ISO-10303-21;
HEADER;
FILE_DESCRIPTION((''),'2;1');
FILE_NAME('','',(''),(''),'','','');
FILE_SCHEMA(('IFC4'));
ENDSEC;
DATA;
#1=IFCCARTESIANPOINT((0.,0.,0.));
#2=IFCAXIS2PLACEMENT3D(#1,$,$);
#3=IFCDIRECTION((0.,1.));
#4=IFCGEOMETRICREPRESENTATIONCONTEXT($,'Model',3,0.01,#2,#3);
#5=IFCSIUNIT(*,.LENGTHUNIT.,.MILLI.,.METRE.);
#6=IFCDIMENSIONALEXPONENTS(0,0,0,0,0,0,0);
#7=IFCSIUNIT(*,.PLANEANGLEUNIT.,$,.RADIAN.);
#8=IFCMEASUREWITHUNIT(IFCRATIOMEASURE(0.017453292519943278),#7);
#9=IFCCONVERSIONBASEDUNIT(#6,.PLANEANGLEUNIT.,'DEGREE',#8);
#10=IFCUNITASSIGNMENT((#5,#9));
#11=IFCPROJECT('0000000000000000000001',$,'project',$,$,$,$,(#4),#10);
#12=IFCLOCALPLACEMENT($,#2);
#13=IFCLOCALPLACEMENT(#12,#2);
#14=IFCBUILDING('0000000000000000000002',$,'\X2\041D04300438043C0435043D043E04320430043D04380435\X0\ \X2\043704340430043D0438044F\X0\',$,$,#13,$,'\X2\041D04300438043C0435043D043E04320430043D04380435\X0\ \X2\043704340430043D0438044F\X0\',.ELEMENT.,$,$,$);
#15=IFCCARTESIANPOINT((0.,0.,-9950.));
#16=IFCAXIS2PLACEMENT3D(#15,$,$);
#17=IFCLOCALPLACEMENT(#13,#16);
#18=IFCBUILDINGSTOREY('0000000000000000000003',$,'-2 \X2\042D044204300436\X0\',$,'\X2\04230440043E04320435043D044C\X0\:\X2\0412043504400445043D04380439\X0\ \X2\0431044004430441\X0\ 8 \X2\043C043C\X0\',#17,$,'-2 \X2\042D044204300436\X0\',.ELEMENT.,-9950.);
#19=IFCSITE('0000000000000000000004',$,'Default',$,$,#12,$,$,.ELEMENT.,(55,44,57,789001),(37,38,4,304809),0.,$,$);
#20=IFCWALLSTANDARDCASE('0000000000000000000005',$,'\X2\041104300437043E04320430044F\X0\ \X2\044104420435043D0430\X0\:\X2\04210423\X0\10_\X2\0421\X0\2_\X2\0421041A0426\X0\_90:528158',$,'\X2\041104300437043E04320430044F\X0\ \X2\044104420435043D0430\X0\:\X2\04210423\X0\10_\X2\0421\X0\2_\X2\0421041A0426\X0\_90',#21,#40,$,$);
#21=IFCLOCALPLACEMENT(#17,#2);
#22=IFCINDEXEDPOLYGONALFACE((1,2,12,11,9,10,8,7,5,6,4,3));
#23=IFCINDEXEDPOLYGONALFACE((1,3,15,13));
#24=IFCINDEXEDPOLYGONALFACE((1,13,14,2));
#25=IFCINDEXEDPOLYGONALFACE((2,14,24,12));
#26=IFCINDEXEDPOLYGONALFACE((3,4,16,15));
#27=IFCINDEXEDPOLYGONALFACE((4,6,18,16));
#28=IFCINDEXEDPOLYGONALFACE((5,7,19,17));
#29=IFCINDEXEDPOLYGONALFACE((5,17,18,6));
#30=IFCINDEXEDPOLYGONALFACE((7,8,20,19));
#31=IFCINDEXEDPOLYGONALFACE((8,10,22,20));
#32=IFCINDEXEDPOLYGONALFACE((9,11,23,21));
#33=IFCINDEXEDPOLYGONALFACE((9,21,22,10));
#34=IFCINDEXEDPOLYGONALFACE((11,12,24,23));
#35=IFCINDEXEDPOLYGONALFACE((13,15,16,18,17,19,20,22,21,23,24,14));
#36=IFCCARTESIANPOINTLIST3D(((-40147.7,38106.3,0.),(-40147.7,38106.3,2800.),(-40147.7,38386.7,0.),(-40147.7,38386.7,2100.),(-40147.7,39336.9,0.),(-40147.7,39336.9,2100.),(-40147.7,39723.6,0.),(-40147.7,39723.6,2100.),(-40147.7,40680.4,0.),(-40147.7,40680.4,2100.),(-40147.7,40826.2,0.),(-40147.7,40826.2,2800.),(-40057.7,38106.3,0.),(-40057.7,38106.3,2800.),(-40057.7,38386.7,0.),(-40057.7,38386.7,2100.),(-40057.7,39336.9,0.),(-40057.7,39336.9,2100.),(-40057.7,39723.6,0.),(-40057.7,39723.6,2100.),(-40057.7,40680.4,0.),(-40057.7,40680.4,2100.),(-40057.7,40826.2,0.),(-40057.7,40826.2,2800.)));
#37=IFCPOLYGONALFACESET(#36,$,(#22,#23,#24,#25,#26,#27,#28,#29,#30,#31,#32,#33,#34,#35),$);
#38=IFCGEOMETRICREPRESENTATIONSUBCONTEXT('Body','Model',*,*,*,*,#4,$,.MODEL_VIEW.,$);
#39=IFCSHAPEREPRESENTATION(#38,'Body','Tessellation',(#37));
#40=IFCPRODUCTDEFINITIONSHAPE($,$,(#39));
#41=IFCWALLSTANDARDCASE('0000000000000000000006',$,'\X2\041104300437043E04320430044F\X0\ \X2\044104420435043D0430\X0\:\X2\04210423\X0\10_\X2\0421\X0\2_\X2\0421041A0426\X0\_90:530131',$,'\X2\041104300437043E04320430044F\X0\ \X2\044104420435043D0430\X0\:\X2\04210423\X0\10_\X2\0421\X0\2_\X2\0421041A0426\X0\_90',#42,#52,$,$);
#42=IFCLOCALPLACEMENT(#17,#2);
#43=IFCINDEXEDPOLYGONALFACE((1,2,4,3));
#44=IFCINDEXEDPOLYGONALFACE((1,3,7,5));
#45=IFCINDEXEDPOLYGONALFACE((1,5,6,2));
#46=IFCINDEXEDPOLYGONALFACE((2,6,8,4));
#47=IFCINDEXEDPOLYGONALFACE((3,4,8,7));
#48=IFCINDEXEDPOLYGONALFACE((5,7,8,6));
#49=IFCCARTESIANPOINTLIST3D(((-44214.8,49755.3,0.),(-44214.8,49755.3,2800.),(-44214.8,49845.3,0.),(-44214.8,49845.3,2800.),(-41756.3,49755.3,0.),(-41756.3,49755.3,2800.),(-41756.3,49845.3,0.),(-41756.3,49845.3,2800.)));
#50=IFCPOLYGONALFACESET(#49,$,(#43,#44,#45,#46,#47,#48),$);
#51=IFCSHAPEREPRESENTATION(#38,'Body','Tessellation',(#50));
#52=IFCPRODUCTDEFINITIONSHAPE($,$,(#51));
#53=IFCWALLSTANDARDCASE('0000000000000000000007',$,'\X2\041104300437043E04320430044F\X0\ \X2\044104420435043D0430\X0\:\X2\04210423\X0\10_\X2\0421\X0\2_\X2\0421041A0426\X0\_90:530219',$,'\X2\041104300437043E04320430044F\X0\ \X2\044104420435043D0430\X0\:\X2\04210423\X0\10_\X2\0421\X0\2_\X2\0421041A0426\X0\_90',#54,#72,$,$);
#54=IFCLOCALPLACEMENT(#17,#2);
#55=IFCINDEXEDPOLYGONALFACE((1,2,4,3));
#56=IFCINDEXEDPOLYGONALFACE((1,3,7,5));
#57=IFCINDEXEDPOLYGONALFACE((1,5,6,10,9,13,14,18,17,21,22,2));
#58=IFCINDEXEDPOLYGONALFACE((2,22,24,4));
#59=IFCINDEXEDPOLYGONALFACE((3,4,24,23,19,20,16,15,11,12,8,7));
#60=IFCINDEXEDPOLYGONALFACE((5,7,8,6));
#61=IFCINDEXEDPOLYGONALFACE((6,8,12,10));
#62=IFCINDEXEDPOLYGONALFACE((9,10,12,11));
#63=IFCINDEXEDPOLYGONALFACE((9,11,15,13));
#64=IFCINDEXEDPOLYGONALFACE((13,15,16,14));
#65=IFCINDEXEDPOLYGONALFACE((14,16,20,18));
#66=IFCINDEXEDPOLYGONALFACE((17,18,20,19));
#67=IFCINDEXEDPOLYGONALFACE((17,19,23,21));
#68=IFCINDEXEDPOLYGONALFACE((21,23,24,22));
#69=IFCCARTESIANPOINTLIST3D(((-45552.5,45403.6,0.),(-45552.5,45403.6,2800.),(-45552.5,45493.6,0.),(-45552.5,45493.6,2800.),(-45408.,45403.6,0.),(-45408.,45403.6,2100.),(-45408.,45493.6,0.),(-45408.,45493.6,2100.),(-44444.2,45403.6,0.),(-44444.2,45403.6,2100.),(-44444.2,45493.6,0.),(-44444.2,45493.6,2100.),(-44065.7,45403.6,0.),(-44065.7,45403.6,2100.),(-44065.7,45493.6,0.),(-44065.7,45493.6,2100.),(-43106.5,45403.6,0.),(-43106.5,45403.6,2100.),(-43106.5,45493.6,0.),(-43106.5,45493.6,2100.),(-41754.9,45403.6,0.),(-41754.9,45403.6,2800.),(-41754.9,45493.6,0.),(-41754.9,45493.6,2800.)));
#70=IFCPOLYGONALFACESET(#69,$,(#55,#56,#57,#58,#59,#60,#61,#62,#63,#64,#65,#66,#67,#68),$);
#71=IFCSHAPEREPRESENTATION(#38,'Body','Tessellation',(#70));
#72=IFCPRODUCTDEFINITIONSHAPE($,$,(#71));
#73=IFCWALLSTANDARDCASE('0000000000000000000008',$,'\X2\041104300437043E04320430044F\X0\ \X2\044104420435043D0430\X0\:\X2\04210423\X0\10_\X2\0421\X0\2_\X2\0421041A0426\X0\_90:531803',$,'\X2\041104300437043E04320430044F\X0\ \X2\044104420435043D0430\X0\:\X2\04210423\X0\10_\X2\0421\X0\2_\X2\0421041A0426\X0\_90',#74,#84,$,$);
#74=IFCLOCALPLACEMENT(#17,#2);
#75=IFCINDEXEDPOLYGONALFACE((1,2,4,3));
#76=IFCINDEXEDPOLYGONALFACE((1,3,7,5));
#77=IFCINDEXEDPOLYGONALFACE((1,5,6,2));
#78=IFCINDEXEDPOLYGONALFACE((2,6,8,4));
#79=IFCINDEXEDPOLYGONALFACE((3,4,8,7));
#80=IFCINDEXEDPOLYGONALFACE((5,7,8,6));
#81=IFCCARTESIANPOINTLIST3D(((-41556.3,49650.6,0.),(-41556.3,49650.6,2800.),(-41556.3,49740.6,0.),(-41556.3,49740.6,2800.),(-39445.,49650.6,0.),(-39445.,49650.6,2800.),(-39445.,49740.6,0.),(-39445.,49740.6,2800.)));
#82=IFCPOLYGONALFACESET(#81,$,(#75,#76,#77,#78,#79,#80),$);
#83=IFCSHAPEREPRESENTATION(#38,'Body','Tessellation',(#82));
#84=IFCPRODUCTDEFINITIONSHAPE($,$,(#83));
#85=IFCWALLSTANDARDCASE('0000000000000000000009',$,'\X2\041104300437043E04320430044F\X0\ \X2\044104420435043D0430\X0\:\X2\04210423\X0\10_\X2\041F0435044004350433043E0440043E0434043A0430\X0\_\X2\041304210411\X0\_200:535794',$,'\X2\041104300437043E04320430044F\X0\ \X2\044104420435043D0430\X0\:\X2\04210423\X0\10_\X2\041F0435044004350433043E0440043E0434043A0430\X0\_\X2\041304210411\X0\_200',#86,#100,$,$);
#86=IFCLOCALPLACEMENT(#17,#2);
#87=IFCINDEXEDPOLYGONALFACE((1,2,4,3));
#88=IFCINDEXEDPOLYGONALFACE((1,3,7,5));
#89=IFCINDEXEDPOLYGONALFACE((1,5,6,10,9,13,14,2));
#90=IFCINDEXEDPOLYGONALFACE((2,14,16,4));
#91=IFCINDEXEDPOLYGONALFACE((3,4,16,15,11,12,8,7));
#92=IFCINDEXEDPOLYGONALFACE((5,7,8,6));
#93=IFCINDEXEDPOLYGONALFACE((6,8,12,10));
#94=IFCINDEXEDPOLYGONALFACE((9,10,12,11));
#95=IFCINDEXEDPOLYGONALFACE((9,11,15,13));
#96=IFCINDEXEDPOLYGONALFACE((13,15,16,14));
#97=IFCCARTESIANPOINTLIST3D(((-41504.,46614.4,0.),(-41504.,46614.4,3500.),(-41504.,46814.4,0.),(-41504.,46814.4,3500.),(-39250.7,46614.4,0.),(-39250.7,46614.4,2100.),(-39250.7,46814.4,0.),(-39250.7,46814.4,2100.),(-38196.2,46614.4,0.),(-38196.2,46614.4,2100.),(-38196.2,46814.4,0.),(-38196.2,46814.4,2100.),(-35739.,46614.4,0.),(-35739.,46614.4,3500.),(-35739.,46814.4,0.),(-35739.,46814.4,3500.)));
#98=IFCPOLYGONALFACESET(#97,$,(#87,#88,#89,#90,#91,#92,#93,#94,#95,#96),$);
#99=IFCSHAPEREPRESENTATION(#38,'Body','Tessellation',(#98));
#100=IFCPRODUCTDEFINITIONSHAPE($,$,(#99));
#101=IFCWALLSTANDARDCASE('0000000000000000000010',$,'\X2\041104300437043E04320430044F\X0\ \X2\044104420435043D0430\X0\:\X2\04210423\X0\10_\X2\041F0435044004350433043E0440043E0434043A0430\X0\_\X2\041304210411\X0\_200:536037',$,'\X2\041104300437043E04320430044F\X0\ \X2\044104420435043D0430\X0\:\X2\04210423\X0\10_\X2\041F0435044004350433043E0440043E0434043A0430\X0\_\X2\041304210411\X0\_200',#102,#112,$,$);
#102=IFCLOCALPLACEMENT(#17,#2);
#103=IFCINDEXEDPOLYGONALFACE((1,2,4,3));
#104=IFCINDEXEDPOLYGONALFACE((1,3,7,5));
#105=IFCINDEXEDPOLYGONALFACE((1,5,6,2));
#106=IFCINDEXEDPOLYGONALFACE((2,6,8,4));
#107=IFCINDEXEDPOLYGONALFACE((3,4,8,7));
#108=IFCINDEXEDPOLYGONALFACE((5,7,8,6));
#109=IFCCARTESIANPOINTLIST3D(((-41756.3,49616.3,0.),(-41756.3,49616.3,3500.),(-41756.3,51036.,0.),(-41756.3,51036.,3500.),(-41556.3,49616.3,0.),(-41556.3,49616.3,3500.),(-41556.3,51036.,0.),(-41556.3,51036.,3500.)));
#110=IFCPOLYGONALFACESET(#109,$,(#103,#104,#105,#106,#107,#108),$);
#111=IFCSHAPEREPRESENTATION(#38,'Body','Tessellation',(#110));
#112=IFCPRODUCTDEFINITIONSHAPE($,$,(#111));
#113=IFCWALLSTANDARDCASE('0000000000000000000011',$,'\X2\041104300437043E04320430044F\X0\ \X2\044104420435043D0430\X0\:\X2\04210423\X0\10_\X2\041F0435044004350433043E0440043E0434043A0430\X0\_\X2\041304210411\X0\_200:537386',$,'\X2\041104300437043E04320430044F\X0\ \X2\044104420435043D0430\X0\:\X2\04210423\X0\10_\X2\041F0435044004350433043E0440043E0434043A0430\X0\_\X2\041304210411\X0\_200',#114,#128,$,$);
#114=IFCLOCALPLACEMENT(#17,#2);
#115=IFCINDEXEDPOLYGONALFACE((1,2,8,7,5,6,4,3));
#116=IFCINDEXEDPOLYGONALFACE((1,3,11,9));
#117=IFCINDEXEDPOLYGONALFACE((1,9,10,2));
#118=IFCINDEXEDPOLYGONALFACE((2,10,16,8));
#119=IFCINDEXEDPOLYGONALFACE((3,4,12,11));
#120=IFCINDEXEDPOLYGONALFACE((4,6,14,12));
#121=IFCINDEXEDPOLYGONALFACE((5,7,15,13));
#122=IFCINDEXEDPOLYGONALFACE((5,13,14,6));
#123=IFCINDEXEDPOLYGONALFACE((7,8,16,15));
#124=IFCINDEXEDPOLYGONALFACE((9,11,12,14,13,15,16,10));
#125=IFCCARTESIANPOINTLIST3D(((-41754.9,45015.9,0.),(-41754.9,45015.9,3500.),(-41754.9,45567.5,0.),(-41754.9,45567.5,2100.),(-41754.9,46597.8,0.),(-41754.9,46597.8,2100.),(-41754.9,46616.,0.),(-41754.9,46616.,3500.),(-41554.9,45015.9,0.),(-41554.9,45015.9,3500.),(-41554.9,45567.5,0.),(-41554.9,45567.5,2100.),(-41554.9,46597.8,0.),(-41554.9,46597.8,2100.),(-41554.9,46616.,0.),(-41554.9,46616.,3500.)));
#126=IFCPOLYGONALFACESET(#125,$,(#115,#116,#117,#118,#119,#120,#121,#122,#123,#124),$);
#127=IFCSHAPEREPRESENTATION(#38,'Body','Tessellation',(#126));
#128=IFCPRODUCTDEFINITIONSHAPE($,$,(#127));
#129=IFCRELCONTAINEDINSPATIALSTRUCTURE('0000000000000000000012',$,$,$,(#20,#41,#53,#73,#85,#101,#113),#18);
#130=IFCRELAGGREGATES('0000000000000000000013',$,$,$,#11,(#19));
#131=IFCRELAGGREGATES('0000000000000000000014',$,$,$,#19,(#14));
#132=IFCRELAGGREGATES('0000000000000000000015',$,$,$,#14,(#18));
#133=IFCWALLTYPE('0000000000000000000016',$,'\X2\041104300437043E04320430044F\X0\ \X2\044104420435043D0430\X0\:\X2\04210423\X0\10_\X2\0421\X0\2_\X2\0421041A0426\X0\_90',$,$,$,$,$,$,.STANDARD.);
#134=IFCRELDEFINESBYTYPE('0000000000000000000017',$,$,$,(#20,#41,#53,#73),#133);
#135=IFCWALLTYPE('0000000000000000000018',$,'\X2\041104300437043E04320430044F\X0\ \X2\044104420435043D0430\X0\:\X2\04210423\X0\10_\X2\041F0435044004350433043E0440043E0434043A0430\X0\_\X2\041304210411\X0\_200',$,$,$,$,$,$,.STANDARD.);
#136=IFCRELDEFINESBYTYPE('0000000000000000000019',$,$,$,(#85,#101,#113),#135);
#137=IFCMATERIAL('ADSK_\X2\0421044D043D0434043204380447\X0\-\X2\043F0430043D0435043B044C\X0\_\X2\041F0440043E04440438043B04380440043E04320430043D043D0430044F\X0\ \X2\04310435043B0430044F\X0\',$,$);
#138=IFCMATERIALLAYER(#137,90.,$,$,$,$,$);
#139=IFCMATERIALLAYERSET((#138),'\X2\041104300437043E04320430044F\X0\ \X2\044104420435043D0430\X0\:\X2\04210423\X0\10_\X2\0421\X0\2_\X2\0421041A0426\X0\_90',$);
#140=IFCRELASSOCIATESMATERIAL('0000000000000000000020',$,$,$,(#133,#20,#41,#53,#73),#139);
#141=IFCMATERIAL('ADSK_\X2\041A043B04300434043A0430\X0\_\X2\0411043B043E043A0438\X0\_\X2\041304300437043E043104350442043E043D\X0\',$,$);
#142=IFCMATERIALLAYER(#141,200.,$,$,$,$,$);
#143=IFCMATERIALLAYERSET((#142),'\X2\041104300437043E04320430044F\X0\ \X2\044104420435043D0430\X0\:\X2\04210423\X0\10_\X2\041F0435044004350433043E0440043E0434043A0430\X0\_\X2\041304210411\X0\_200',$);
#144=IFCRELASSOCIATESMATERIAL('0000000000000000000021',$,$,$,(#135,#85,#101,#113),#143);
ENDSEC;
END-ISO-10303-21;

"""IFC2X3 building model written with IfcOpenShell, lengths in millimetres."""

from ifc_helpers import new_model, entity, si_unit, converted_unit, direction, frame, frame_2d, origin, place, context, subcontext, project, spatial, rectangle, extrude, material, layer, layer_set, layer_usage, type_object, element, save


model = new_model("IFC2X3")

# Units and contexts
model_context = context("Model", 3, precision=0.01, world=origin(), true_north=direction((0.0, 1.0)))
body_context = subcontext(model_context, "Body", "Model", "MODEL_VIEW")
ifc_project = project(units=[si_unit("LENGTHUNIT", "METRE", prefix="MILLI"), converted_unit("PLANEANGLEUNIT", "DEGREE", entity("IfcRatioMeasure", 0.017453292519943278), si_unit("PLANEANGLEUNIT", "RADIAN"), dimensions=[0, 0, 0, 0, 0, 0, 0])], contexts=[model_context])

# Site, building, storey
site_placement = place(None, origin())
site = spatial("IfcSite", under=ifc_project, at=site_placement, Name="Default", CompositionType="ELEMENT", RefLatitude=(55, 44, 57, 789001), RefLongitude=(37, 38, 4, 304809), RefElevation=0.0)
building_placement = place(site_placement, origin())
building = spatial("IfcBuilding", under=site, at=building_placement, Name="Наименование здания", LongName="Наименование здания", CompositionType="ELEMENT")
storey_placement = place(building_placement, frame((0.0, 0.0, -9950.0)))
storey = spatial("IfcBuildingStorey", under=building, at=storey_placement, Name="-2 Этаж", ObjectType="Уровень:Верхний брус 8 мм", LongName="-2 Этаж", CompositionType="ELEMENT", Elevation=-9950.0)

# Shared definitions
ifc_material_1 = material(Name="ADSK_Сэндвич-панель_Профилированная белая")
ifc_layer_1 = layer(ifc_material_1, 90.0)
ifc_layer_set_1 = layer_set([ifc_layer_1], Name="Базовая стена:СУ10_С2_СКЦ_90")
ifc_layer_usage_1 = layer_usage(ifc_layer_set_1, "AXIS2", "NEGATIVE", 45.0)
wall_type_1 = type_object("IfcWallType", Name="Базовая стена:СУ10_С2_СКЦ_90", PredefinedType="STANDARD", material=ifc_layer_set_1)

# Wall, openings
wall_1_placement = place(storey_placement, frame((-40102.7, 40826.2, 0.0), z_axis=(0.0, 0.0, 1.0), x_axis=(0.0, -1.0, 0.0)))
wall_1 = element("IfcWallStandardCase", 1, at=wall_1_placement, inside=storey, type_object=wall_type_1, material=ifc_layer_usage_1, Name="Базовая стена:СУ10_С2_СКЦ_90:528158", ObjectType="Базовая стена:СУ10_С2_СКЦ_90", context=body_context, shape_type="SweptSolid", body=[
    extrude(rectangle(XDim=2719.9, YDim=90.0, at=frame_2d((1359.9, 0.0), x_axis=(1.0, 0.0))), origin(), (0.0, 0.0, 1.0), 2800.0),
])
opening_1_placement = place(wall_1_placement, origin())
element("IfcOpeningElement", 2, at=opening_1_placement, cuts=wall_1, ObjectType="Opening", context=body_context, shape_type="SweptSolid", body=[
    extrude(rectangle(XDim=2100.0, YDim=956.8, at=frame_2d((0.0, 0.0), x_axis=(1.0, 0.0))), frame((624.2, -45.0, 1050.0), z_axis=(0.0, 1.0, 0.0), x_axis=(0.0, 0.0, -1.0)), (0.0, 0.0, 1.0), 90.0),
])
opening_2_placement = place(wall_1_placement, origin())
element("IfcOpeningElement", 3, at=opening_2_placement, cuts=wall_1, ObjectType="Opening", context=body_context, shape_type="SweptSolid", body=[
    extrude(rectangle(XDim=2100.0, YDim=950.2, at=frame_2d((0.0, 0.0), x_axis=(1.0, 0.0))), frame((1964.4, -45.0, 1050.0), z_axis=(0.0, 1.0, 0.0), x_axis=(0.0, 0.0, -1.0)), (0.0, 0.0, 1.0), 90.0),
])

# Wall
wall_2_placement = place(storey_placement, frame((-41756.3, 49800.3, 0.0), z_axis=(0.0, 0.0, 1.0), x_axis=(-1.0, 0.0, 0.0)))
element("IfcWallStandardCase", 4, at=wall_2_placement, inside=storey, type_object=wall_type_1, material=ifc_layer_usage_1, Name="Базовая стена:СУ10_С2_СКЦ_90:530131", ObjectType="Базовая стена:СУ10_С2_СКЦ_90", context=body_context, shape_type="SweptSolid", body=[
    extrude(rectangle(XDim=2458.5, YDim=90.0, at=frame_2d((1229.2, 0.0), x_axis=(-1.0, 0.0))), origin(), (0.0, 0.0, 1.0), 2800.0),
])

# Wall, openings
wall_3_placement = place(storey_placement, frame((-41754.9, 45448.6, 0.0), z_axis=(0.0, 0.0, 1.0), x_axis=(-1.0, 0.0, 0.0)))
wall_3 = element("IfcWallStandardCase", 5, at=wall_3_placement, inside=storey, type_object=wall_type_1, material=ifc_layer_usage_1, Name="Базовая стена:СУ10_С2_СКЦ_90:530219", ObjectType="Базовая стена:СУ10_С2_СКЦ_90", context=body_context, shape_type="SweptSolid", body=[
    extrude(rectangle(XDim=3797.6, YDim=90.0, at=frame_2d((1898.8, 0.0), x_axis=(1.0, 0.0))), origin(), (0.0, 0.0, 1.0), 2800.0),
])
opening_3_placement = place(wall_3_placement, origin())
element("IfcOpeningElement", 6, at=opening_3_placement, cuts=wall_3, ObjectType="Opening", context=body_context, shape_type="SweptSolid", body=[
    extrude(rectangle(XDim=2100.0, YDim=963.8, at=frame_2d((0.0, 0.0), x_axis=(1.0, 0.0))), frame((3171.2, -45.0, 1050.0), z_axis=(0.0, 1.0, 0.0), x_axis=(0.0, 0.0, -1.0)), (0.0, 0.0, 1.0), 90.0),
])
opening_4_placement = place(wall_3_placement, origin())
element("IfcOpeningElement", 7, at=opening_4_placement, cuts=wall_3, ObjectType="Opening", context=body_context, shape_type="SweptSolid", body=[
    extrude(rectangle(XDim=2100.0, YDim=959.3, at=frame_2d((0.0, 0.0), x_axis=(1.0, 0.0))), frame((1831.2, -45.0, 1050.0), z_axis=(0.0, 1.0, 0.0), x_axis=(0.0, 0.0, -1.0)), (0.0, 0.0, 1.0), 90.0),
])

# Wall
wall_4_placement = place(storey_placement, frame((-39445.0, 49695.6, 0.0), z_axis=(0.0, 0.0, 1.0), x_axis=(-1.0, 0.0, 0.0)))
element("IfcWallStandardCase", 8, at=wall_4_placement, inside=storey, type_object=wall_type_1, material=ifc_layer_usage_1, Name="Базовая стена:СУ10_С2_СКЦ_90:531803", ObjectType="Базовая стена:СУ10_С2_СКЦ_90", context=body_context, shape_type="SweptSolid", body=[
    extrude(rectangle(XDim=2111.3, YDim=90.0, at=frame_2d((1055.6, 0.0), x_axis=(-1.0, 0.0))), origin(), (0.0, 0.0, 1.0), 2800.0),
])

# Wall, opening
ifc_material_2 = material(Name="ADSK_Кладка_Блоки_Газобетон")
ifc_layer_2 = layer(ifc_material_2, 200.0)
ifc_layer_set_2 = layer_set([ifc_layer_2], Name="Базовая стена:СУ10_Перегородка_ГСБ_200")
ifc_layer_usage_2 = layer_usage(ifc_layer_set_2, "AXIS2", "NEGATIVE", 100.0)
wall_type_2 = type_object("IfcWallType", Name="Базовая стена:СУ10_Перегородка_ГСБ_200", PredefinedType="STANDARD", material=ifc_layer_set_2)
wall_5_placement = place(storey_placement, frame((-35739.0, 46714.4, 0.0), z_axis=(0.0, 0.0, 1.0), x_axis=(-1.0, 0.0, 0.0)))
wall_5 = element("IfcWallStandardCase", 9, at=wall_5_placement, inside=storey, type_object=wall_type_2, material=ifc_layer_usage_2, Name="Базовая стена:СУ10_Перегородка_ГСБ_200:535794", ObjectType="Базовая стена:СУ10_Перегородка_ГСБ_200", context=body_context, shape_type="SweptSolid", body=[
    extrude(rectangle(XDim=5765.0, YDim=200.0, at=frame_2d((2882.5, 0.0), x_axis=(-1.0, 0.0))), origin(), (0.0, 0.0, 1.0), 3500.0),
])
opening_5_placement = place(wall_5_placement, origin())
element("IfcOpeningElement", 10, at=opening_5_placement, cuts=wall_5, ObjectType="Opening", context=body_context, shape_type="SweptSolid", body=[
    extrude(rectangle(XDim=2100.0, YDim=1054.4, at=frame_2d((0.0, 0.0), x_axis=(1.0, 0.0))), frame((2984.5, -100.0, 1050.0), z_axis=(0.0, 1.0, 0.0), x_axis=(0.0, 0.0, -1.0)), (0.0, 0.0, 1.0), 200.0),
])

# Wall
wall_6_placement = place(storey_placement, frame((-41656.3, 49616.3, 0.0), z_axis=(0.0, 0.0, 1.0), x_axis=(0.0, 1.0, 0.0)))
element("IfcWallStandardCase", 11, at=wall_6_placement, inside=storey, type_object=wall_type_2, material=ifc_layer_usage_2, Name="Базовая стена:СУ10_Перегородка_ГСБ_200:536037", ObjectType="Базовая стена:СУ10_Перегородка_ГСБ_200", context=body_context, shape_type="SweptSolid", body=[
    extrude(rectangle(XDim=1419.7, YDim=200.0, at=frame_2d((709.9, 0.0), x_axis=(-1.0, 0.0))), origin(), (0.0, 0.0, 1.0), 3500.0),
])

# Wall, opening
wall_7_placement = place(storey_placement, frame((-41654.9, 45015.9, 0.0), z_axis=(0.0, 0.0, 1.0), x_axis=(0.0, 1.0, 0.0)))
wall_7 = element("IfcWallStandardCase", 12, at=wall_7_placement, inside=storey, type_object=wall_type_2, material=ifc_layer_usage_2, Name="Базовая стена:СУ10_Перегородка_ГСБ_200:537386", ObjectType="Базовая стена:СУ10_Перегородка_ГСБ_200", context=body_context, shape_type="SweptSolid", body=[
    extrude(rectangle(XDim=1600.1, YDim=200.0, at=frame_2d((800.0, 0.0), x_axis=(-1.0, 0.0))), origin(), (0.0, 0.0, 1.0), 3500.0),
])
opening_6_placement = place(wall_7_placement, origin())
element("IfcOpeningElement", 13, at=opening_6_placement, cuts=wall_7, ObjectType="Opening", context=body_context, shape_type="SweptSolid", body=[
    extrude(rectangle(XDim=2100.0, YDim=1030.2, at=frame_2d((0.0, 0.0), x_axis=(1.0, 0.0))), frame((1066.7, -100.0, 1050.0), z_axis=(0.0, 1.0, 0.0), x_axis=(0.0, 0.0, -1.0)), (0.0, 0.0, 1.0), 200.0),
])

save(model, "model.ifc")
